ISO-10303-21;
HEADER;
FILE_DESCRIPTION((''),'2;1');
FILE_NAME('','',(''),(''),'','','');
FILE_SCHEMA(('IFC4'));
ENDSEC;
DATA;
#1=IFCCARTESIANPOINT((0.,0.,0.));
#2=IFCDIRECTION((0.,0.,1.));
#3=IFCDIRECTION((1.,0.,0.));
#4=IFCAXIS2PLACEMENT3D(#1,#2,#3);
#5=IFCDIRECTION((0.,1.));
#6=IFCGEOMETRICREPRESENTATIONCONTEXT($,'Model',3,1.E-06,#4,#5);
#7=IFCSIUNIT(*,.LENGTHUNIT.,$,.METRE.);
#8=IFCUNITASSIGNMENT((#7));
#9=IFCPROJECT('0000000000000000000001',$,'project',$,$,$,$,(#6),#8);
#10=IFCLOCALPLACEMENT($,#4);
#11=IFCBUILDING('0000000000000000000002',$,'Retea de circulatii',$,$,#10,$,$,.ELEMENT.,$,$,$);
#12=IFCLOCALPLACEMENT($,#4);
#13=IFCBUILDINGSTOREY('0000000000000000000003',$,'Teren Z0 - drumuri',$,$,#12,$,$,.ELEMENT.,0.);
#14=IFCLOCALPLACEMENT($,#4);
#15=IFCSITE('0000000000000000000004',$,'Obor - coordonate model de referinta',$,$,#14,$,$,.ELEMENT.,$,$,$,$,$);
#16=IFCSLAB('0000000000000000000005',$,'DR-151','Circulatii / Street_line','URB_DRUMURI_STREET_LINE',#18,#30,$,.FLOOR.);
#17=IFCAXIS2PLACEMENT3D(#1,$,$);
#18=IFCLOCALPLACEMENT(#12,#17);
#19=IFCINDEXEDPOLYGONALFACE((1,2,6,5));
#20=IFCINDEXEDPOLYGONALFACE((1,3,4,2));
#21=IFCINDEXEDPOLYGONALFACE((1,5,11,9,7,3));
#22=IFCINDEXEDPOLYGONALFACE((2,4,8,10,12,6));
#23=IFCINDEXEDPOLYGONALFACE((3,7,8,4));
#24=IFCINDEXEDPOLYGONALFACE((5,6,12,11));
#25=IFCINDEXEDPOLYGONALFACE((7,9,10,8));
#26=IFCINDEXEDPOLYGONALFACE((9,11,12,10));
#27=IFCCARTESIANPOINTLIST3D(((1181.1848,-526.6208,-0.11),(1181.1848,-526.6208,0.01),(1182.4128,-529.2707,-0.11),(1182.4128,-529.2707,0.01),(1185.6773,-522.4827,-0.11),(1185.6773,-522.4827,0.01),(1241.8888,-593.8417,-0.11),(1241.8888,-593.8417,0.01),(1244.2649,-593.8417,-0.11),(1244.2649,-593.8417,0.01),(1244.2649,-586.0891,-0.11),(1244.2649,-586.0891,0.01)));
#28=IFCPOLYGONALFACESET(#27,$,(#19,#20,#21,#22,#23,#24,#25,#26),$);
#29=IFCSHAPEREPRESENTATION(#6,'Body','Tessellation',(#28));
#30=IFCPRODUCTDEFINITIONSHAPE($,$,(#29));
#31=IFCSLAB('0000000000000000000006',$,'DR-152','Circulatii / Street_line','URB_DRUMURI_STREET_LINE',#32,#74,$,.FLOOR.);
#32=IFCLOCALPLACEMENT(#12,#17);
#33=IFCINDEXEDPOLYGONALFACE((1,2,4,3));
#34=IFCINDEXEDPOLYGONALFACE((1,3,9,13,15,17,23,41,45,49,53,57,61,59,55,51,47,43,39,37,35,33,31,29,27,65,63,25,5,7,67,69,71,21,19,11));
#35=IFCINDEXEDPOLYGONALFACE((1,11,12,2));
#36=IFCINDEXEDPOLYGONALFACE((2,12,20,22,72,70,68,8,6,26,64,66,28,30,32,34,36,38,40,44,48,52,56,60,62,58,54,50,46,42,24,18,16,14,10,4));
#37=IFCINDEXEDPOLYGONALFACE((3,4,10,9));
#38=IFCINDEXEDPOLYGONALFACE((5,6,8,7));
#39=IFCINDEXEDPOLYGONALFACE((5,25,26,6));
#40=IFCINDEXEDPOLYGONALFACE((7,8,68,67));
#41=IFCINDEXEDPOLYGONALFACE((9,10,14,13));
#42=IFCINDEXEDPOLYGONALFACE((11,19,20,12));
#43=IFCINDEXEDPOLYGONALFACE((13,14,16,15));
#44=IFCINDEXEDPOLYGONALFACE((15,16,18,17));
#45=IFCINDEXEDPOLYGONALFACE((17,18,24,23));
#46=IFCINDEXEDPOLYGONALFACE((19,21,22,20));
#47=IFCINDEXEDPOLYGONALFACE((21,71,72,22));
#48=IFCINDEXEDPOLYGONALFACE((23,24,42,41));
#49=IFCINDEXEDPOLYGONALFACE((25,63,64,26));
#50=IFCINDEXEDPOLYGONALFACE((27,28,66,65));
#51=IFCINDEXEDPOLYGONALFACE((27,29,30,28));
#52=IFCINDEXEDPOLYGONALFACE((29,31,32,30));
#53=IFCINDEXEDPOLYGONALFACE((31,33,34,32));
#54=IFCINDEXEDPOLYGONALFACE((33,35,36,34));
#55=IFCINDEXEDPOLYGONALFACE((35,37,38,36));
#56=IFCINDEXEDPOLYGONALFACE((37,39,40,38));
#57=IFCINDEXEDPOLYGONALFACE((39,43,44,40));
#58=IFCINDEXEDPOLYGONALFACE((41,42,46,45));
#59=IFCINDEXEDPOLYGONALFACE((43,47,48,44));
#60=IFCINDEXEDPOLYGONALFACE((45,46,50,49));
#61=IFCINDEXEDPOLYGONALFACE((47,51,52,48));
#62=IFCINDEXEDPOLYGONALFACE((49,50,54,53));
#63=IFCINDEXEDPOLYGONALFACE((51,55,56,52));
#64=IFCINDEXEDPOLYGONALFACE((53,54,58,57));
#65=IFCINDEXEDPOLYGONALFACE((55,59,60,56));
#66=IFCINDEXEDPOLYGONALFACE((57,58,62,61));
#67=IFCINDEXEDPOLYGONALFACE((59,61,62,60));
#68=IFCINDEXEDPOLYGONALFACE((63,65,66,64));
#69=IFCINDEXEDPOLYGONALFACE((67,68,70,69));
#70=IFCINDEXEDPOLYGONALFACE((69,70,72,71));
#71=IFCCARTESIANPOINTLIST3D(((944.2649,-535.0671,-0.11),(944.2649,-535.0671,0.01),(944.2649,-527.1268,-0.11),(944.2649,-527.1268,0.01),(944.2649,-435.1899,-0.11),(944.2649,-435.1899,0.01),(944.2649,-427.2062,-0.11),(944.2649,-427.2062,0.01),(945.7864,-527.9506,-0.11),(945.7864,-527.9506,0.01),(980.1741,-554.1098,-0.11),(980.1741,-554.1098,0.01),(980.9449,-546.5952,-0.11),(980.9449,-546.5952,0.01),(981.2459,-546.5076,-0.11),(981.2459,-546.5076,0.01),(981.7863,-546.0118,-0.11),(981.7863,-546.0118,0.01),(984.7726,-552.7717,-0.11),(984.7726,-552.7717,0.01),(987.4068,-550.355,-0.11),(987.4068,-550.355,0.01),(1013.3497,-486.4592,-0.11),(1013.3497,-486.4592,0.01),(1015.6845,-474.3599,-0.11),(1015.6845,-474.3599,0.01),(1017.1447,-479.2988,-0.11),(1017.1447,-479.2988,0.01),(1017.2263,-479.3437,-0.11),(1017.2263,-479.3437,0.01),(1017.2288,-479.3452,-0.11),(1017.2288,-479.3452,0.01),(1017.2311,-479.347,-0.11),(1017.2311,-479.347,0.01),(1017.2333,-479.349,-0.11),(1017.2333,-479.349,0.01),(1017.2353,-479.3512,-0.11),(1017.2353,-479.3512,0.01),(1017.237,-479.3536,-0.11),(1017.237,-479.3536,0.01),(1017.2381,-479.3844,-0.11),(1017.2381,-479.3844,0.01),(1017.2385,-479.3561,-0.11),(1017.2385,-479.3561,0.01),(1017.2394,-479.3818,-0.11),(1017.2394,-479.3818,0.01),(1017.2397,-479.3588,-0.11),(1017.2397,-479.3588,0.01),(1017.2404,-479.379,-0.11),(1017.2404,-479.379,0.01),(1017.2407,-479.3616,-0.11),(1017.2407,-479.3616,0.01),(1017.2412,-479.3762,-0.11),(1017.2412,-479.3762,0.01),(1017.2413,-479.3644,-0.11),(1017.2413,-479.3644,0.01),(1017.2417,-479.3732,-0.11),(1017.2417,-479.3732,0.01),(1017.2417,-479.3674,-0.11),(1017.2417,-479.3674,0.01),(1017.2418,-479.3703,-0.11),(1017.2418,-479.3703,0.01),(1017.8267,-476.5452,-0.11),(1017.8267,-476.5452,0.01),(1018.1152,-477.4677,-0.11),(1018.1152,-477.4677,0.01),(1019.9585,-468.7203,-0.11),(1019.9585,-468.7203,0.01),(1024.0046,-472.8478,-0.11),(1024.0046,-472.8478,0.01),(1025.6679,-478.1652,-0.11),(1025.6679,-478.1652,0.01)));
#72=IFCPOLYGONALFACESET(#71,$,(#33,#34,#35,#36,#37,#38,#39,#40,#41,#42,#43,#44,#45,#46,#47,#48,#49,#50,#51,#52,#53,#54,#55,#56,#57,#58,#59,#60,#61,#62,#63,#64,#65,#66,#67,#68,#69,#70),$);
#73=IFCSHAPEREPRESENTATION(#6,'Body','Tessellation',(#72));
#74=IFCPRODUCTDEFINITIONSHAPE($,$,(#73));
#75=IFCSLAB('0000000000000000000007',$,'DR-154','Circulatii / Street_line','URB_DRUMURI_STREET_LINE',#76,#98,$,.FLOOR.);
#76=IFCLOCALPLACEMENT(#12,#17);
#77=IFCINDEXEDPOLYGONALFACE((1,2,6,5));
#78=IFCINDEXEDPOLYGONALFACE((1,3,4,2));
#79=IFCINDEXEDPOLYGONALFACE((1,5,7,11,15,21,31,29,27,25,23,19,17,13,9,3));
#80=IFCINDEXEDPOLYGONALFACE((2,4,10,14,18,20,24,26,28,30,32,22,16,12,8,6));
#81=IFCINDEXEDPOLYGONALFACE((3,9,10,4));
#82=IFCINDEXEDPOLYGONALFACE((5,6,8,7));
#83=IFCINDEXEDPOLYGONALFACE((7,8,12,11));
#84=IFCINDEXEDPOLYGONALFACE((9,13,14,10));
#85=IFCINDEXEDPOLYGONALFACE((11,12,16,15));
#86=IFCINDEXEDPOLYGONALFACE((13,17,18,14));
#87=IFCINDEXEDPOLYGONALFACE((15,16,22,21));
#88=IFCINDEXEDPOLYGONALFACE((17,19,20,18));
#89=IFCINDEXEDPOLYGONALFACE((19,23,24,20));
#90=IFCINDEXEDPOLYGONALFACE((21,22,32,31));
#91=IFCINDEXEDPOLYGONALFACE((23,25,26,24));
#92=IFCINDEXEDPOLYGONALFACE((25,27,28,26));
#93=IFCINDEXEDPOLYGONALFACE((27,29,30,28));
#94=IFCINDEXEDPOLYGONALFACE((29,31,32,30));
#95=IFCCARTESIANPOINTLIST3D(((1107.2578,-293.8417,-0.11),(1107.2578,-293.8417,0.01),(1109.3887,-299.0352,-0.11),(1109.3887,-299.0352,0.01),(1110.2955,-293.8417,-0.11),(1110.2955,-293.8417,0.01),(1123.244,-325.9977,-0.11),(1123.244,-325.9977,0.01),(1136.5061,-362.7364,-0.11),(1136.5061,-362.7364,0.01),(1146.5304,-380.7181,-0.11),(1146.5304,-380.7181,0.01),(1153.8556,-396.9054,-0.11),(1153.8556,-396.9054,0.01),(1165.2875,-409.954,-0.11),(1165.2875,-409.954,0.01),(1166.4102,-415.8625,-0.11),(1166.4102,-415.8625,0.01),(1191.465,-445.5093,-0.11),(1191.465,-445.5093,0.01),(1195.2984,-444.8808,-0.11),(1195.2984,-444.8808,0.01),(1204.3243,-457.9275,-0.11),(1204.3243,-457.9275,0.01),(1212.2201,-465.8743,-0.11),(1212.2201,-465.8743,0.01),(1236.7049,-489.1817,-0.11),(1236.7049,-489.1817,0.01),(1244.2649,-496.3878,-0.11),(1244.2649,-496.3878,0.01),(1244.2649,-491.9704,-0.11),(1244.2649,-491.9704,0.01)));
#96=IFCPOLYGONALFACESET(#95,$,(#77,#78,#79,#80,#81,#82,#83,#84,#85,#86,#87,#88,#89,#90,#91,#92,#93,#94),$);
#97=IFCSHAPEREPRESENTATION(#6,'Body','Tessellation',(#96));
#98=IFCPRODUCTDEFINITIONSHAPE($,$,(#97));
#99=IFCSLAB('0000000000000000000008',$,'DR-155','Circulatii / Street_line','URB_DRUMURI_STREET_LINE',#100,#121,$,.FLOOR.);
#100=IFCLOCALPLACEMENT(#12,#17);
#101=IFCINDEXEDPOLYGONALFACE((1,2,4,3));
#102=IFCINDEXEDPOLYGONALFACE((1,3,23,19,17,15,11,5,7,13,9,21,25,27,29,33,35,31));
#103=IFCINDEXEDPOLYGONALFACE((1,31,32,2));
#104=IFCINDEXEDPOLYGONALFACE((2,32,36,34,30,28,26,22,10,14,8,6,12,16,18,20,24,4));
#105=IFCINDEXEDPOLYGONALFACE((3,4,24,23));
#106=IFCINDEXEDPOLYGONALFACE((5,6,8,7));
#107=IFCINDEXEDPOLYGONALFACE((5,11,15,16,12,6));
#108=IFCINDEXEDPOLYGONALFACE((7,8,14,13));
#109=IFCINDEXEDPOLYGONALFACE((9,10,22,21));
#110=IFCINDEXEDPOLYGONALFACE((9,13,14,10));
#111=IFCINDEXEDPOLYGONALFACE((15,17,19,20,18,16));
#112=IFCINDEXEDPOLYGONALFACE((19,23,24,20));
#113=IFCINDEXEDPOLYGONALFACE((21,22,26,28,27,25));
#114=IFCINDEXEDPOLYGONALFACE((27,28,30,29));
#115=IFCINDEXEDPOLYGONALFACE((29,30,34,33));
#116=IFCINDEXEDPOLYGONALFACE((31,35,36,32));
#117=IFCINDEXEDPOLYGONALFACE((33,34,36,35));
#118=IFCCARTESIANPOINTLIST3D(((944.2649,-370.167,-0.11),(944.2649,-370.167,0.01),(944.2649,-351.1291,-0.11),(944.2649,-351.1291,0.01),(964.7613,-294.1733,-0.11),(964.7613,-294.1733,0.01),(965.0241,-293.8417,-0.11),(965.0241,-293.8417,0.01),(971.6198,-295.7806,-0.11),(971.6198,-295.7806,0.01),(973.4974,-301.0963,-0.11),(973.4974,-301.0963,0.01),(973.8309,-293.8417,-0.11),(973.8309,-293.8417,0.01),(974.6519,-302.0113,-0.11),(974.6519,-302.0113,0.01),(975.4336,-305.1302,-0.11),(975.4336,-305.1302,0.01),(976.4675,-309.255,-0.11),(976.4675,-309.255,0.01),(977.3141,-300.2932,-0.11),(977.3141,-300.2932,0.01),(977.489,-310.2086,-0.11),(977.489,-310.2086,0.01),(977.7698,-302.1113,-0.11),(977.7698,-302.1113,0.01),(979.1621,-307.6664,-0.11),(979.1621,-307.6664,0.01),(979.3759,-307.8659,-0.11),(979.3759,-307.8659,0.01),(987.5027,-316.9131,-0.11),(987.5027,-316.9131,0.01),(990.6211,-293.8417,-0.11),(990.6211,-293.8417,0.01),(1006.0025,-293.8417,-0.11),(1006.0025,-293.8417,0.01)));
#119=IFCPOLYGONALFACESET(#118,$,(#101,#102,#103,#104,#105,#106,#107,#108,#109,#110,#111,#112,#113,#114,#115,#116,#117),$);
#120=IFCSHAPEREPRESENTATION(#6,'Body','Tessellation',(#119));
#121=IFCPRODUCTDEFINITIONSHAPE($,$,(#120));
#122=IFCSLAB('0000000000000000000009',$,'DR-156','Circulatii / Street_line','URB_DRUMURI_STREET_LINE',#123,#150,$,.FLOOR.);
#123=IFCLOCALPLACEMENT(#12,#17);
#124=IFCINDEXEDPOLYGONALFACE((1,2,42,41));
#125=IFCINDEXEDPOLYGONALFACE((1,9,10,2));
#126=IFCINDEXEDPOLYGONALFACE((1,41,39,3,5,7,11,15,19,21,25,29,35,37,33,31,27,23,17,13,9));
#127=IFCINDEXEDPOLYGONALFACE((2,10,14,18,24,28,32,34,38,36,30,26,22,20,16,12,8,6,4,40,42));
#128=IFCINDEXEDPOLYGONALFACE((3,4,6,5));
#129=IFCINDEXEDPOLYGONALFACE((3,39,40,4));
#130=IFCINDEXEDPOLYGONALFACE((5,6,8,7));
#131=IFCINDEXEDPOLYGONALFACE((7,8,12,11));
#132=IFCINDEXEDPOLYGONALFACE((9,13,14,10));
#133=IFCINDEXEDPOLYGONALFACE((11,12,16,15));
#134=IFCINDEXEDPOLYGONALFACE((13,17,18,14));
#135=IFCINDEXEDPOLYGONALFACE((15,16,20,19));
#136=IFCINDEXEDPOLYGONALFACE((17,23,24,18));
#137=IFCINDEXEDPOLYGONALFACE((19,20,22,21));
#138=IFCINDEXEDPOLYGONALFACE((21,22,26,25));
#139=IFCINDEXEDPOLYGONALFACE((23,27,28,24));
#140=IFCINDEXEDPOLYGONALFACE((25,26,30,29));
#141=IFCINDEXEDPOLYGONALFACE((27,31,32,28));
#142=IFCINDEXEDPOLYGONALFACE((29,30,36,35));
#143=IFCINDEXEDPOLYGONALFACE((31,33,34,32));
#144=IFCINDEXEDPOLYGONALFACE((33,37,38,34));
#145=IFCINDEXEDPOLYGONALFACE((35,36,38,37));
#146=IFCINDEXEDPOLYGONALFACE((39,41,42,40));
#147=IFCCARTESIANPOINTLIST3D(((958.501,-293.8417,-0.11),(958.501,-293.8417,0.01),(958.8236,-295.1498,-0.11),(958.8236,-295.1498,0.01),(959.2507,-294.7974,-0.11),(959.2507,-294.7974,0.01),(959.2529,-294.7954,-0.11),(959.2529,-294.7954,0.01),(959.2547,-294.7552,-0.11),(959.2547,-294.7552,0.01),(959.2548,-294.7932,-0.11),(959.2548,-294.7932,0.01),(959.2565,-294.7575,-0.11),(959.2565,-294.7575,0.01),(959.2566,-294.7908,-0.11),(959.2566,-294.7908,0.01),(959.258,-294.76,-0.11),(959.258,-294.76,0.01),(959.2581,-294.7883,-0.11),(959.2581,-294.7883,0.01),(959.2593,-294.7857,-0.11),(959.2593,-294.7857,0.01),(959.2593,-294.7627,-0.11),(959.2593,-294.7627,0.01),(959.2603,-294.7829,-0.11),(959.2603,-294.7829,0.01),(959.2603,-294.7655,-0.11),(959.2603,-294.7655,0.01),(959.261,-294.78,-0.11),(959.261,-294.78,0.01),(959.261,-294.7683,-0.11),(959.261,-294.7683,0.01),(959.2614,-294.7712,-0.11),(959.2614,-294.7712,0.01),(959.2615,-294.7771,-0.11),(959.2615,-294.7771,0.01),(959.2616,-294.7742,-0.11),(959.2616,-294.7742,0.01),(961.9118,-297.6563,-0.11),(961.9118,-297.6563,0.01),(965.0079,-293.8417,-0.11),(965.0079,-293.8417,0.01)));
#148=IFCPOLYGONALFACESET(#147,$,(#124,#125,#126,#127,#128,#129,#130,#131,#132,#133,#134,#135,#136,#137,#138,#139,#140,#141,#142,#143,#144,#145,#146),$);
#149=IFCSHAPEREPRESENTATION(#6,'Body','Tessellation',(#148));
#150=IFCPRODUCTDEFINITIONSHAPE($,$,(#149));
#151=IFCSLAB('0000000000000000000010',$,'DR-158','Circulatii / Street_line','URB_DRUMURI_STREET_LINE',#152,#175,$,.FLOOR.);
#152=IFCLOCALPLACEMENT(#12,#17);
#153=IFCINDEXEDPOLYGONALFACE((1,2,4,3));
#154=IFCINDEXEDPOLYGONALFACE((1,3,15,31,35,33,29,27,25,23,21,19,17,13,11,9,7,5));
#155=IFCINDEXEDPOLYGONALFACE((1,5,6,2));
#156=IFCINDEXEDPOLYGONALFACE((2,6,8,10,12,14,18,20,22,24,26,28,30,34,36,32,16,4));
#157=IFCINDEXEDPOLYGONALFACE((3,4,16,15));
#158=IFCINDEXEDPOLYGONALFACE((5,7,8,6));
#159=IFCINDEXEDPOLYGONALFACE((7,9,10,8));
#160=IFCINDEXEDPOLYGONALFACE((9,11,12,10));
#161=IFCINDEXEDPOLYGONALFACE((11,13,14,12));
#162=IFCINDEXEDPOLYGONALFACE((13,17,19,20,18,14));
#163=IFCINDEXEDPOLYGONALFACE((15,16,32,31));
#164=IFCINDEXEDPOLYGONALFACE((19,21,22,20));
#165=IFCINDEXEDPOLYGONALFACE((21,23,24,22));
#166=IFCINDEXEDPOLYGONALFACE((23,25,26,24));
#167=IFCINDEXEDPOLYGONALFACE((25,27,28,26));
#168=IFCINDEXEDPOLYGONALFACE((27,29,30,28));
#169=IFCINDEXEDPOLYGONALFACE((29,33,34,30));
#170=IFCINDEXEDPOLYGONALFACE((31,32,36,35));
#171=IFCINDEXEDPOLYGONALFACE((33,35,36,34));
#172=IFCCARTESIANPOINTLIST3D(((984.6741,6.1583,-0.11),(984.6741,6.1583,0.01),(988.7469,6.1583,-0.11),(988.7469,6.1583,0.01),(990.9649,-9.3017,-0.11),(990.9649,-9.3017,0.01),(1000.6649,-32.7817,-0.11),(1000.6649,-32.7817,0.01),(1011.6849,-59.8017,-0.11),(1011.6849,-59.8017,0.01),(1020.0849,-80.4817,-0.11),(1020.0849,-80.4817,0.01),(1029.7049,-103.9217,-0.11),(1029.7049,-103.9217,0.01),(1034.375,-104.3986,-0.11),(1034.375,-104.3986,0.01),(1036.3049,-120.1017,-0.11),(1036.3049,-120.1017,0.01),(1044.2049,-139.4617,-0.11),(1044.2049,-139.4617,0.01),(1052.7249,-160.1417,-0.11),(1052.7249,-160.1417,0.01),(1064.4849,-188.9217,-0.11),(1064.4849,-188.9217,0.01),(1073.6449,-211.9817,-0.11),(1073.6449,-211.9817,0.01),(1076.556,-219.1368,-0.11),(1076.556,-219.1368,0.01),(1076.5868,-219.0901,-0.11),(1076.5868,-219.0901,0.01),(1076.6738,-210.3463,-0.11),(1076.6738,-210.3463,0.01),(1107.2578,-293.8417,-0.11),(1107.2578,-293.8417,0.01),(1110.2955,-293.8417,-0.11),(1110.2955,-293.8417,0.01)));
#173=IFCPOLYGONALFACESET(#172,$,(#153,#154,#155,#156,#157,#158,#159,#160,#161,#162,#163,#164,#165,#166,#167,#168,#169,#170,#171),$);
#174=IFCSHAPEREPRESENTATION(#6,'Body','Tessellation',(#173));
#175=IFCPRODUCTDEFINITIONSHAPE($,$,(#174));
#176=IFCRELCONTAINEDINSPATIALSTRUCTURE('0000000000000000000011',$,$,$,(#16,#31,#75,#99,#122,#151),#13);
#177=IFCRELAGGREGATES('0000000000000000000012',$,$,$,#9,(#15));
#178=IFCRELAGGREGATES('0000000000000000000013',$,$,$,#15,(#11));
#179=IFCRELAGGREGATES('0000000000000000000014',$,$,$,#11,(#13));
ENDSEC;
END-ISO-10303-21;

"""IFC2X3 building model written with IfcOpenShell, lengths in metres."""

from ifc_helpers import new_model, si_unit, direction, frame, origin_with_axes, place, context, project, spatial, polyline, outline, extrude, element, save


model = new_model("IFC2X3")

# Units and contexts
model_context = context("Model", 3, precision=1e-06, world=origin_with_axes(), true_north=direction((0.0, 1.0)))
ifc_project = project(units=[si_unit("LENGTHUNIT", "METRE")], contexts=[model_context])

# Site, building, storey
site_placement = place(None, origin_with_axes())
site = spatial("IfcSite", under=ifc_project, at=site_placement, Name="Obor - coordonate model de referinta", CompositionType="ELEMENT")
building_placement = place(None, origin_with_axes())
building = spatial("IfcBuilding", under=site, at=building_placement, Name="Retea de circulatii", CompositionType="ELEMENT")
storey_placement = place(None, origin_with_axes())
storey = spatial("IfcBuildingStorey", under=building, at=storey_placement, Name="Teren Z0 - drumuri", CompositionType="ELEMENT", Elevation=0.0)

# Slabs
slab_1_placement = place(None, origin_with_axes())
element("IfcSlab", 1, at=slab_1_placement, inside=storey, Name="DR-151", Description="Circulatii / Street_line", ObjectType="URB_DRUMURI_STREET_LINE", PredefinedType="FLOOR", context=model_context, shape_type="SweptSolid", body=[
    extrude(outline(polyline([(1244.2649, -586.0891), (1185.6773, -522.4827), (1181.1848, -526.6208), (1182.4128, -529.2707), (1241.8888, -593.8417), (1244.2649, -593.8417), (1244.2649, -586.0891)])), frame((0.0, 0.0, -0.11), z_axis=(0.0, 0.0, 1.0), x_axis=(1.0, 0.0, 0.0)), (0.0, 0.0, 1.0), 0.12),
])
slab_2_placement = place(None, origin_with_axes())
element("IfcSlab", 2, at=slab_2_placement, inside=storey, Name="DR-152", Description="Circulatii / Street_line", ObjectType="URB_DRUMURI_STREET_LINE", PredefinedType="FLOOR", context=model_context, shape_type="SweptSolid", body=[
    extrude(outline(polyline([(987.4068, -550.355), (1025.6679, -478.1652), (1024.0046, -472.8478), (1019.9585, -468.7203), (944.2649, -427.2062), (944.2649, -435.1899), (1015.6845, -474.3599), (1017.8267, -476.5452), (1018.1152, -477.4677), (1017.1447, -479.2988), (1017.2263, -479.3437), (1017.2288, -479.3452), (1017.2311, -479.347), (1017.2333, -479.349), (1017.2353, -479.3512), (1017.237, -479.3536), (1017.2385, -479.3561), (1017.2397, -479.3588), (1017.2407, -479.3616), (1017.2413, -479.3644), (1017.2417, -479.3674), (1017.2418, -479.3703), (1017.2417, -479.3732), (1017.2412, -479.3762), (1017.2404, -479.379), (1017.2394, -479.3818), (1017.2381, -479.3844), (1013.3497, -486.4592), (981.7863, -546.0118), (981.2459, -546.5076), (980.9449, -546.5952), (945.7864, -527.9506), (944.2649, -527.1268), (944.2649, -535.0671), (980.1741, -554.1098), (984.7726, -552.7717), (987.4068, -550.355)])), frame((0.0, 0.0, -0.11), z_axis=(0.0, 0.0, 1.0), x_axis=(1.0, 0.0, 0.0)), (0.0, 0.0, 1.0), 0.12),
])
slab_3_placement = place(None, origin_with_axes())
element("IfcSlab", 3, at=slab_3_placement, inside=storey, Name="DR-154", Description="Circulatii / Street_line", ObjectType="URB_DRUMURI_STREET_LINE", PredefinedType="FLOOR", context=model_context, shape_type="SweptSolid", body=[
    extrude(outline(polyline([(1195.2984, -444.8808), (1165.2875, -409.954), (1146.5304, -380.7181), (1123.244, -325.9977), (1110.2955, -293.8417), (1107.2578, -293.8417), (1109.3887, -299.0352), (1136.5061, -362.7364), (1153.8556, -396.9054), (1166.4102, -415.8625), (1191.465, -445.5093), (1204.3243, -457.9275), (1212.2201, -465.8743), (1236.7049, -489.1817), (1244.2649, -496.3878), (1244.2649, -491.9704), (1195.2984, -444.8808)])), frame((0.0, 0.0, -0.11), z_axis=(0.0, 0.0, 1.0), x_axis=(1.0, 0.0, 0.0)), (0.0, 0.0, 1.0), 0.12),
])
slab_4_placement = place(None, origin_with_axes())
element("IfcSlab", 4, at=slab_4_placement, inside=storey, Name="DR-155", Description="Circulatii / Street_line", ObjectType="URB_DRUMURI_STREET_LINE", PredefinedType="FLOOR", context=model_context, shape_type="SweptSolid", body=[
    extrude(outline(polyline([(974.6519, -302.0113), (975.4336, -305.1302), (976.4675, -309.255), (977.489, -310.2086), (944.2649, -351.1291), (944.2649, -370.167), (987.5027, -316.9131), (1006.0025, -293.8417), (990.6211, -293.8417), (979.3759, -307.8659), (979.1621, -307.6664), (977.7698, -302.1113), (977.3141, -300.2932), (971.6198, -295.7806), (973.8309, -293.8417), (965.0241, -293.8417), (964.7613, -294.1733), (973.4974, -301.0963), (974.6519, -302.0113)])), frame((0.0, 0.0, -0.11), z_axis=(0.0, 0.0, 1.0), x_axis=(1.0, 0.0, 0.0)), (0.0, 0.0, 1.0), 0.12),
])
slab_5_placement = place(None, origin_with_axes())
element("IfcSlab", 5, at=slab_5_placement, inside=storey, Name="DR-156", Description="Circulatii / Street_line", ObjectType="URB_DRUMURI_STREET_LINE", PredefinedType="FLOOR", context=model_context, shape_type="SweptSolid", body=[
    extrude(outline(polyline([(959.2529, -294.7954), (959.2507, -294.7974), (958.8236, -295.1498), (961.9118, -297.6563), (965.0079, -293.8417), (958.501, -293.8417), (959.2547, -294.7552), (959.2565, -294.7575), (959.258, -294.76), (959.2593, -294.7627), (959.2603, -294.7655), (959.261, -294.7683), (959.2614, -294.7712), (959.2616, -294.7742), (959.2615, -294.7771), (959.261, -294.78), (959.2603, -294.7829), (959.2593, -294.7857), (959.2581, -294.7883), (959.2566, -294.7908), (959.2548, -294.7932), (959.2529, -294.7954)])), frame((0.0, 0.0, -0.11), z_axis=(0.0, 0.0, 1.0), x_axis=(1.0, 0.0, 0.0)), (0.0, 0.0, 1.0), 0.12),
])
slab_6_placement = place(None, origin_with_axes())
element("IfcSlab", 6, at=slab_6_placement, inside=storey, Name="DR-158", Description="Circulatii / Street_line", ObjectType="URB_DRUMURI_STREET_LINE", PredefinedType="FLOOR", context=model_context, shape_type="SweptSolid", body=[
    extrude(outline(polyline([(1110.2955, -293.8417), (1076.6738, -210.3463), (1034.375, -104.3986), (988.7469, 6.1583), (984.6741, 6.1583), (990.9649, -9.3017), (1000.6649, -32.7817), (1011.6849, -59.8017), (1020.0849, -80.4817), (1029.7049, -103.9217), (1036.3049, -120.1017), (1044.2049, -139.4617), (1052.7249, -160.1417), (1064.4849, -188.9217), (1073.6449, -211.9817), (1076.556, -219.1368), (1076.5868, -219.0901), (1107.2578, -293.8417), (1110.2955, -293.8417)])), frame((0.0, 0.0, -0.11), z_axis=(0.0, 0.0, 1.0), x_axis=(1.0, 0.0, 0.0)), (0.0, 0.0, 1.0), 0.12),
])

save(model, "model.ifc")
